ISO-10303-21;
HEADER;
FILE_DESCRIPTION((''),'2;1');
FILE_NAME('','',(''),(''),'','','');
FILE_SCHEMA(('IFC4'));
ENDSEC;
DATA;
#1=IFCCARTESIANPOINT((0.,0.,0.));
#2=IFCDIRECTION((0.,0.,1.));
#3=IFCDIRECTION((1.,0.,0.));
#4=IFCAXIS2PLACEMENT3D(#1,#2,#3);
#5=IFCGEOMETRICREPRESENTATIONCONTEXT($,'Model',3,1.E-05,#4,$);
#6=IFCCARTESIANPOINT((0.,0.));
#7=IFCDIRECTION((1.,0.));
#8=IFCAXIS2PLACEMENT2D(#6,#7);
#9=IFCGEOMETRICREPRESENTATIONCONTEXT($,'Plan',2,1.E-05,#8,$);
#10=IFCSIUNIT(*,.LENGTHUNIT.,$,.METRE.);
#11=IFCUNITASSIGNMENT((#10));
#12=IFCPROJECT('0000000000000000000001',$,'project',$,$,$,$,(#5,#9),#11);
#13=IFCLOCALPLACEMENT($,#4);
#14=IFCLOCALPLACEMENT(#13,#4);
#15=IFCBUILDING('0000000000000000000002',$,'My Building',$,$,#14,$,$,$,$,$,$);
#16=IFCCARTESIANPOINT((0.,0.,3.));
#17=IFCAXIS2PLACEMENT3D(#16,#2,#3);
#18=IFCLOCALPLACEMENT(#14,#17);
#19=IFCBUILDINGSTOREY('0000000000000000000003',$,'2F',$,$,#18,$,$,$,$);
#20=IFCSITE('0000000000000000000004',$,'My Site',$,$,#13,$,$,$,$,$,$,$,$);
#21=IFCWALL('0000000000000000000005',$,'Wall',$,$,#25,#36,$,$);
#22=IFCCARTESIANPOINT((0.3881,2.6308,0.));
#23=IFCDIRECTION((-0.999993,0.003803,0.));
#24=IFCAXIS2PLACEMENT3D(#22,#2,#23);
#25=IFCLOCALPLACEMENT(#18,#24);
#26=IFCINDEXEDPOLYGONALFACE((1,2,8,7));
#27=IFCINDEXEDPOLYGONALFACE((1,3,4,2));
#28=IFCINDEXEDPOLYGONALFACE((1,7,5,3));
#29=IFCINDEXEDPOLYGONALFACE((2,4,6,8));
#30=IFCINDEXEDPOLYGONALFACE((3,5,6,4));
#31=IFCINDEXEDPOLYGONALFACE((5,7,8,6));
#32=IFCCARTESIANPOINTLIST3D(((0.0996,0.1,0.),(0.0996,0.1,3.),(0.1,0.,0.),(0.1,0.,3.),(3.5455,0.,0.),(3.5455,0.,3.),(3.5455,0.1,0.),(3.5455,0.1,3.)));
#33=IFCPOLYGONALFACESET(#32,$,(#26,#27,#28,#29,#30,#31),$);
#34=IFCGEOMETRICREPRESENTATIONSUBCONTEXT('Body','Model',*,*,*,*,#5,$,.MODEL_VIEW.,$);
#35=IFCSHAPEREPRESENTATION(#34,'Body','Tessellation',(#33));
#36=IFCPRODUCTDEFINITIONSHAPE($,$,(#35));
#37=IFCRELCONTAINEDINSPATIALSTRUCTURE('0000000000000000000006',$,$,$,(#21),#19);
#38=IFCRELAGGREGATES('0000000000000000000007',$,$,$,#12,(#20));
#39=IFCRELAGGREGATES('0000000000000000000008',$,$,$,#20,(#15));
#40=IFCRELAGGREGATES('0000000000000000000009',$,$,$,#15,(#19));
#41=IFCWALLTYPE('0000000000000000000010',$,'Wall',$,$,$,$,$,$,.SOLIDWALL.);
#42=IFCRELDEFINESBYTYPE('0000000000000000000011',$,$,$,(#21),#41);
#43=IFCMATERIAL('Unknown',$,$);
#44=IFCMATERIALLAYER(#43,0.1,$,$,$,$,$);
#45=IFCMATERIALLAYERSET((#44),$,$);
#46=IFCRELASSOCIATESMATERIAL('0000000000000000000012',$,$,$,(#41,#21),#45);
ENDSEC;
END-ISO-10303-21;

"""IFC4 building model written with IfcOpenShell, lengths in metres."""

from ifc_helpers import new_model, si_unit, frame, origin_with_axes, origin_2d_with_axis, place, context, subcontext, project, spatial, line, indexed_curve, outline, extrude, material, layer, layer_set, layer_usage, type_object, element, save


model = new_model("IFC4")

# Units and contexts
model_context = context("Model", 3, precision=1e-05, world=origin_with_axes())
plan_context = context("Plan", 2, precision=1e-05, world=origin_2d_with_axis())
body_context_1 = subcontext(model_context, "Body", "Model", "MODEL_VIEW")
ifc_project = project(units=[si_unit("LENGTHUNIT", "METRE")], contexts=[model_context, plan_context])

# Site, building, storey
site_placement = place(None, origin_with_axes())
site = spatial("IfcSite", under=ifc_project, at=site_placement, Name="My Site")
building_placement = place(site_placement, origin_with_axes())
building = spatial("IfcBuilding", under=site, at=building_placement, Name="My Building")
storey_placement = place(building_placement, frame((0.0, 0.0, 3.0), z_axis=(0.0, 0.0, 1.0), x_axis=(1.0, 0.0, 0.0)))
storey = spatial("IfcBuildingStorey", under=building, at=storey_placement, Name="2F")

# Shared definitions
ifc_material = material(Name="Unknown")

# Shared definitions
ifc_layer_1 = layer(ifc_material, 0.1)
ifc_layer_set_1 = layer_set([ifc_layer_1])
wall_type = type_object("IfcWallType", Name="Wall", PredefinedType="SOLIDWALL", material=ifc_layer_set_1)

# Wall
ifc_layer_usage_1 = layer_usage(ifc_layer_set_1, "AXIS2", "POSITIVE", 0.0)
wall_1_placement = place(storey_placement, frame((0.3881, 2.6308, 0.0), z_axis=(0.0, 0.0, 1.0), x_axis=(-0.999993, 0.003803, 0.0)))
element("IfcWall", 1, at=wall_1_placement, inside=storey, type_object=wall_type, material=ifc_layer_usage_1, Name="Wall", context=body_context_1, shape_type="SweptSolid", body=[
    extrude(outline(indexed_curve([(0.1, 0.0), (0.0996, 0.1), (3.5455, 0.1), (3.5455, 0.0)], segments=[line(1, 2, 3, 4, 1)])), origin_with_axes(), (0.0, 0.0, 1.0), 3.0),
])

save(model, "model.ifc")
